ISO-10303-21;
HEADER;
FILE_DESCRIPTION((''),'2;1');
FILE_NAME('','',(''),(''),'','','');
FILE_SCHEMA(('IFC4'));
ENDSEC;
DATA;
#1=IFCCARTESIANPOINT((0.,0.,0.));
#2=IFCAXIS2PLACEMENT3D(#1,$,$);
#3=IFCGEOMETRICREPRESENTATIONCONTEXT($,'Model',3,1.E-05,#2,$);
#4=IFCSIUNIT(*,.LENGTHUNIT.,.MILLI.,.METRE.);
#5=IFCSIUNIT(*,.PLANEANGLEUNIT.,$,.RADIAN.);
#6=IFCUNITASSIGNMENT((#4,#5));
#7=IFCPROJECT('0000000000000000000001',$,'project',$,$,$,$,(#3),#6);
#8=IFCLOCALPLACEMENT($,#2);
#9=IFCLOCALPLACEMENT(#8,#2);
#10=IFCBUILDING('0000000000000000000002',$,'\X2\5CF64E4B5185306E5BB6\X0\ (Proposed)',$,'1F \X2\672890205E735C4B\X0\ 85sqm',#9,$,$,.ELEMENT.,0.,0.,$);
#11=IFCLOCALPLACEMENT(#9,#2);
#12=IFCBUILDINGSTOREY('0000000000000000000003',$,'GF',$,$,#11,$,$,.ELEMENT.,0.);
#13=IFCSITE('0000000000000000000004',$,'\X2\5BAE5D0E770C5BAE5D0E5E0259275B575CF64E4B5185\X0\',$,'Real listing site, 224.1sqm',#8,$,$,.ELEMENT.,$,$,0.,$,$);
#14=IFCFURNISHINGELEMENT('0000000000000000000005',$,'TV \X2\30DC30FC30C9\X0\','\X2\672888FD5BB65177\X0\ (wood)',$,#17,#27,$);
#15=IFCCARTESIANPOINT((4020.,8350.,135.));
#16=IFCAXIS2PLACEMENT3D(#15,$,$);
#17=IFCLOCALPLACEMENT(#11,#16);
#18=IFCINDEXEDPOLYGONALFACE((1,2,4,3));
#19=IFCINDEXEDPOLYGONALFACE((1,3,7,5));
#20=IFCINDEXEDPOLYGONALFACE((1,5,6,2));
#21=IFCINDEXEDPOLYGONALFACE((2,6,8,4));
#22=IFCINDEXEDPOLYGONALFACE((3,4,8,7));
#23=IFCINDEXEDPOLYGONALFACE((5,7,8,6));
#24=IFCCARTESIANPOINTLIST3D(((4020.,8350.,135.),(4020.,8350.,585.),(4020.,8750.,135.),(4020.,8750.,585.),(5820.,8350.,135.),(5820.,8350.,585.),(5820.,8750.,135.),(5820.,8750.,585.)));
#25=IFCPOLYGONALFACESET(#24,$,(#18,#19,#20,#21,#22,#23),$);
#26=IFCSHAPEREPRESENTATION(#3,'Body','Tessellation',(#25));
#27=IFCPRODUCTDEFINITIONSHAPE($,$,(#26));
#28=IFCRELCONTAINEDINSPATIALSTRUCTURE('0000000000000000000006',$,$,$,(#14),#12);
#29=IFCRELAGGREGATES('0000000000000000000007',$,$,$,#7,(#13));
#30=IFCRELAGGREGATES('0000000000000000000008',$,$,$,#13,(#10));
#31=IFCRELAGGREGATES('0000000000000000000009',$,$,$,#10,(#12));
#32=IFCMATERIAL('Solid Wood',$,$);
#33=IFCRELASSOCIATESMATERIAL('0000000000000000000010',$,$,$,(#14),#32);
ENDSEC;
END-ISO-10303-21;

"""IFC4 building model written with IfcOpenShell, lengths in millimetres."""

from ifc_helpers import new_model, si_unit, frame, frame_2d, origin, place, context, project, spatial, rectangle, extrude, material, element, save


model = new_model("IFC4")

# Units and contexts
model_context = context("Model", 3, precision=1e-05, world=origin())
ifc_project = project(units=[si_unit("LENGTHUNIT", "METRE", prefix="MILLI"), si_unit("PLANEANGLEUNIT", "RADIAN")], contexts=[model_context])

# Site, building, storey
site_placement = place(None, origin())
site = spatial("IfcSite", under=ifc_project, at=site_placement, Name="宮崎県宮崎市大字島之内", ObjectType="Real listing site, 224.1sqm", CompositionType="ELEMENT", RefElevation=0.0)
building_placement = place(site_placement, origin())
building = spatial("IfcBuilding", under=site, at=building_placement, Name="島之内の家 (Proposed)", ObjectType="1F 木造平屋 85sqm", CompositionType="ELEMENT", ElevationOfRefHeight=0.0, ElevationOfTerrain=0.0)
storey_placement = place(building_placement, origin())
storey = spatial("IfcBuildingStorey", under=building, at=storey_placement, Name="GF", CompositionType="ELEMENT", Elevation=0.0)

# Shared definitions
ifc_material_1 = material(Name="Solid Wood")

# Furnishing element
furnishing_placement = place(storey_placement, frame((4020.0, 8350.0, 135.0)))
element("IfcFurnishingElement", 1, at=furnishing_placement, inside=storey, material=ifc_material_1, Name="TV ボード", Description="木製家具 (wood)", context=model_context, shape_type="SweptSolid", body=[
    extrude(rectangle(XDim=1800.0, YDim=400.0, at=frame_2d((900.0, 200.0))), frame((4020.0, 8350.0, 135.0)), (0.0, 0.0, 1.0), 450.0),
])

save(model, "model.ifc")
